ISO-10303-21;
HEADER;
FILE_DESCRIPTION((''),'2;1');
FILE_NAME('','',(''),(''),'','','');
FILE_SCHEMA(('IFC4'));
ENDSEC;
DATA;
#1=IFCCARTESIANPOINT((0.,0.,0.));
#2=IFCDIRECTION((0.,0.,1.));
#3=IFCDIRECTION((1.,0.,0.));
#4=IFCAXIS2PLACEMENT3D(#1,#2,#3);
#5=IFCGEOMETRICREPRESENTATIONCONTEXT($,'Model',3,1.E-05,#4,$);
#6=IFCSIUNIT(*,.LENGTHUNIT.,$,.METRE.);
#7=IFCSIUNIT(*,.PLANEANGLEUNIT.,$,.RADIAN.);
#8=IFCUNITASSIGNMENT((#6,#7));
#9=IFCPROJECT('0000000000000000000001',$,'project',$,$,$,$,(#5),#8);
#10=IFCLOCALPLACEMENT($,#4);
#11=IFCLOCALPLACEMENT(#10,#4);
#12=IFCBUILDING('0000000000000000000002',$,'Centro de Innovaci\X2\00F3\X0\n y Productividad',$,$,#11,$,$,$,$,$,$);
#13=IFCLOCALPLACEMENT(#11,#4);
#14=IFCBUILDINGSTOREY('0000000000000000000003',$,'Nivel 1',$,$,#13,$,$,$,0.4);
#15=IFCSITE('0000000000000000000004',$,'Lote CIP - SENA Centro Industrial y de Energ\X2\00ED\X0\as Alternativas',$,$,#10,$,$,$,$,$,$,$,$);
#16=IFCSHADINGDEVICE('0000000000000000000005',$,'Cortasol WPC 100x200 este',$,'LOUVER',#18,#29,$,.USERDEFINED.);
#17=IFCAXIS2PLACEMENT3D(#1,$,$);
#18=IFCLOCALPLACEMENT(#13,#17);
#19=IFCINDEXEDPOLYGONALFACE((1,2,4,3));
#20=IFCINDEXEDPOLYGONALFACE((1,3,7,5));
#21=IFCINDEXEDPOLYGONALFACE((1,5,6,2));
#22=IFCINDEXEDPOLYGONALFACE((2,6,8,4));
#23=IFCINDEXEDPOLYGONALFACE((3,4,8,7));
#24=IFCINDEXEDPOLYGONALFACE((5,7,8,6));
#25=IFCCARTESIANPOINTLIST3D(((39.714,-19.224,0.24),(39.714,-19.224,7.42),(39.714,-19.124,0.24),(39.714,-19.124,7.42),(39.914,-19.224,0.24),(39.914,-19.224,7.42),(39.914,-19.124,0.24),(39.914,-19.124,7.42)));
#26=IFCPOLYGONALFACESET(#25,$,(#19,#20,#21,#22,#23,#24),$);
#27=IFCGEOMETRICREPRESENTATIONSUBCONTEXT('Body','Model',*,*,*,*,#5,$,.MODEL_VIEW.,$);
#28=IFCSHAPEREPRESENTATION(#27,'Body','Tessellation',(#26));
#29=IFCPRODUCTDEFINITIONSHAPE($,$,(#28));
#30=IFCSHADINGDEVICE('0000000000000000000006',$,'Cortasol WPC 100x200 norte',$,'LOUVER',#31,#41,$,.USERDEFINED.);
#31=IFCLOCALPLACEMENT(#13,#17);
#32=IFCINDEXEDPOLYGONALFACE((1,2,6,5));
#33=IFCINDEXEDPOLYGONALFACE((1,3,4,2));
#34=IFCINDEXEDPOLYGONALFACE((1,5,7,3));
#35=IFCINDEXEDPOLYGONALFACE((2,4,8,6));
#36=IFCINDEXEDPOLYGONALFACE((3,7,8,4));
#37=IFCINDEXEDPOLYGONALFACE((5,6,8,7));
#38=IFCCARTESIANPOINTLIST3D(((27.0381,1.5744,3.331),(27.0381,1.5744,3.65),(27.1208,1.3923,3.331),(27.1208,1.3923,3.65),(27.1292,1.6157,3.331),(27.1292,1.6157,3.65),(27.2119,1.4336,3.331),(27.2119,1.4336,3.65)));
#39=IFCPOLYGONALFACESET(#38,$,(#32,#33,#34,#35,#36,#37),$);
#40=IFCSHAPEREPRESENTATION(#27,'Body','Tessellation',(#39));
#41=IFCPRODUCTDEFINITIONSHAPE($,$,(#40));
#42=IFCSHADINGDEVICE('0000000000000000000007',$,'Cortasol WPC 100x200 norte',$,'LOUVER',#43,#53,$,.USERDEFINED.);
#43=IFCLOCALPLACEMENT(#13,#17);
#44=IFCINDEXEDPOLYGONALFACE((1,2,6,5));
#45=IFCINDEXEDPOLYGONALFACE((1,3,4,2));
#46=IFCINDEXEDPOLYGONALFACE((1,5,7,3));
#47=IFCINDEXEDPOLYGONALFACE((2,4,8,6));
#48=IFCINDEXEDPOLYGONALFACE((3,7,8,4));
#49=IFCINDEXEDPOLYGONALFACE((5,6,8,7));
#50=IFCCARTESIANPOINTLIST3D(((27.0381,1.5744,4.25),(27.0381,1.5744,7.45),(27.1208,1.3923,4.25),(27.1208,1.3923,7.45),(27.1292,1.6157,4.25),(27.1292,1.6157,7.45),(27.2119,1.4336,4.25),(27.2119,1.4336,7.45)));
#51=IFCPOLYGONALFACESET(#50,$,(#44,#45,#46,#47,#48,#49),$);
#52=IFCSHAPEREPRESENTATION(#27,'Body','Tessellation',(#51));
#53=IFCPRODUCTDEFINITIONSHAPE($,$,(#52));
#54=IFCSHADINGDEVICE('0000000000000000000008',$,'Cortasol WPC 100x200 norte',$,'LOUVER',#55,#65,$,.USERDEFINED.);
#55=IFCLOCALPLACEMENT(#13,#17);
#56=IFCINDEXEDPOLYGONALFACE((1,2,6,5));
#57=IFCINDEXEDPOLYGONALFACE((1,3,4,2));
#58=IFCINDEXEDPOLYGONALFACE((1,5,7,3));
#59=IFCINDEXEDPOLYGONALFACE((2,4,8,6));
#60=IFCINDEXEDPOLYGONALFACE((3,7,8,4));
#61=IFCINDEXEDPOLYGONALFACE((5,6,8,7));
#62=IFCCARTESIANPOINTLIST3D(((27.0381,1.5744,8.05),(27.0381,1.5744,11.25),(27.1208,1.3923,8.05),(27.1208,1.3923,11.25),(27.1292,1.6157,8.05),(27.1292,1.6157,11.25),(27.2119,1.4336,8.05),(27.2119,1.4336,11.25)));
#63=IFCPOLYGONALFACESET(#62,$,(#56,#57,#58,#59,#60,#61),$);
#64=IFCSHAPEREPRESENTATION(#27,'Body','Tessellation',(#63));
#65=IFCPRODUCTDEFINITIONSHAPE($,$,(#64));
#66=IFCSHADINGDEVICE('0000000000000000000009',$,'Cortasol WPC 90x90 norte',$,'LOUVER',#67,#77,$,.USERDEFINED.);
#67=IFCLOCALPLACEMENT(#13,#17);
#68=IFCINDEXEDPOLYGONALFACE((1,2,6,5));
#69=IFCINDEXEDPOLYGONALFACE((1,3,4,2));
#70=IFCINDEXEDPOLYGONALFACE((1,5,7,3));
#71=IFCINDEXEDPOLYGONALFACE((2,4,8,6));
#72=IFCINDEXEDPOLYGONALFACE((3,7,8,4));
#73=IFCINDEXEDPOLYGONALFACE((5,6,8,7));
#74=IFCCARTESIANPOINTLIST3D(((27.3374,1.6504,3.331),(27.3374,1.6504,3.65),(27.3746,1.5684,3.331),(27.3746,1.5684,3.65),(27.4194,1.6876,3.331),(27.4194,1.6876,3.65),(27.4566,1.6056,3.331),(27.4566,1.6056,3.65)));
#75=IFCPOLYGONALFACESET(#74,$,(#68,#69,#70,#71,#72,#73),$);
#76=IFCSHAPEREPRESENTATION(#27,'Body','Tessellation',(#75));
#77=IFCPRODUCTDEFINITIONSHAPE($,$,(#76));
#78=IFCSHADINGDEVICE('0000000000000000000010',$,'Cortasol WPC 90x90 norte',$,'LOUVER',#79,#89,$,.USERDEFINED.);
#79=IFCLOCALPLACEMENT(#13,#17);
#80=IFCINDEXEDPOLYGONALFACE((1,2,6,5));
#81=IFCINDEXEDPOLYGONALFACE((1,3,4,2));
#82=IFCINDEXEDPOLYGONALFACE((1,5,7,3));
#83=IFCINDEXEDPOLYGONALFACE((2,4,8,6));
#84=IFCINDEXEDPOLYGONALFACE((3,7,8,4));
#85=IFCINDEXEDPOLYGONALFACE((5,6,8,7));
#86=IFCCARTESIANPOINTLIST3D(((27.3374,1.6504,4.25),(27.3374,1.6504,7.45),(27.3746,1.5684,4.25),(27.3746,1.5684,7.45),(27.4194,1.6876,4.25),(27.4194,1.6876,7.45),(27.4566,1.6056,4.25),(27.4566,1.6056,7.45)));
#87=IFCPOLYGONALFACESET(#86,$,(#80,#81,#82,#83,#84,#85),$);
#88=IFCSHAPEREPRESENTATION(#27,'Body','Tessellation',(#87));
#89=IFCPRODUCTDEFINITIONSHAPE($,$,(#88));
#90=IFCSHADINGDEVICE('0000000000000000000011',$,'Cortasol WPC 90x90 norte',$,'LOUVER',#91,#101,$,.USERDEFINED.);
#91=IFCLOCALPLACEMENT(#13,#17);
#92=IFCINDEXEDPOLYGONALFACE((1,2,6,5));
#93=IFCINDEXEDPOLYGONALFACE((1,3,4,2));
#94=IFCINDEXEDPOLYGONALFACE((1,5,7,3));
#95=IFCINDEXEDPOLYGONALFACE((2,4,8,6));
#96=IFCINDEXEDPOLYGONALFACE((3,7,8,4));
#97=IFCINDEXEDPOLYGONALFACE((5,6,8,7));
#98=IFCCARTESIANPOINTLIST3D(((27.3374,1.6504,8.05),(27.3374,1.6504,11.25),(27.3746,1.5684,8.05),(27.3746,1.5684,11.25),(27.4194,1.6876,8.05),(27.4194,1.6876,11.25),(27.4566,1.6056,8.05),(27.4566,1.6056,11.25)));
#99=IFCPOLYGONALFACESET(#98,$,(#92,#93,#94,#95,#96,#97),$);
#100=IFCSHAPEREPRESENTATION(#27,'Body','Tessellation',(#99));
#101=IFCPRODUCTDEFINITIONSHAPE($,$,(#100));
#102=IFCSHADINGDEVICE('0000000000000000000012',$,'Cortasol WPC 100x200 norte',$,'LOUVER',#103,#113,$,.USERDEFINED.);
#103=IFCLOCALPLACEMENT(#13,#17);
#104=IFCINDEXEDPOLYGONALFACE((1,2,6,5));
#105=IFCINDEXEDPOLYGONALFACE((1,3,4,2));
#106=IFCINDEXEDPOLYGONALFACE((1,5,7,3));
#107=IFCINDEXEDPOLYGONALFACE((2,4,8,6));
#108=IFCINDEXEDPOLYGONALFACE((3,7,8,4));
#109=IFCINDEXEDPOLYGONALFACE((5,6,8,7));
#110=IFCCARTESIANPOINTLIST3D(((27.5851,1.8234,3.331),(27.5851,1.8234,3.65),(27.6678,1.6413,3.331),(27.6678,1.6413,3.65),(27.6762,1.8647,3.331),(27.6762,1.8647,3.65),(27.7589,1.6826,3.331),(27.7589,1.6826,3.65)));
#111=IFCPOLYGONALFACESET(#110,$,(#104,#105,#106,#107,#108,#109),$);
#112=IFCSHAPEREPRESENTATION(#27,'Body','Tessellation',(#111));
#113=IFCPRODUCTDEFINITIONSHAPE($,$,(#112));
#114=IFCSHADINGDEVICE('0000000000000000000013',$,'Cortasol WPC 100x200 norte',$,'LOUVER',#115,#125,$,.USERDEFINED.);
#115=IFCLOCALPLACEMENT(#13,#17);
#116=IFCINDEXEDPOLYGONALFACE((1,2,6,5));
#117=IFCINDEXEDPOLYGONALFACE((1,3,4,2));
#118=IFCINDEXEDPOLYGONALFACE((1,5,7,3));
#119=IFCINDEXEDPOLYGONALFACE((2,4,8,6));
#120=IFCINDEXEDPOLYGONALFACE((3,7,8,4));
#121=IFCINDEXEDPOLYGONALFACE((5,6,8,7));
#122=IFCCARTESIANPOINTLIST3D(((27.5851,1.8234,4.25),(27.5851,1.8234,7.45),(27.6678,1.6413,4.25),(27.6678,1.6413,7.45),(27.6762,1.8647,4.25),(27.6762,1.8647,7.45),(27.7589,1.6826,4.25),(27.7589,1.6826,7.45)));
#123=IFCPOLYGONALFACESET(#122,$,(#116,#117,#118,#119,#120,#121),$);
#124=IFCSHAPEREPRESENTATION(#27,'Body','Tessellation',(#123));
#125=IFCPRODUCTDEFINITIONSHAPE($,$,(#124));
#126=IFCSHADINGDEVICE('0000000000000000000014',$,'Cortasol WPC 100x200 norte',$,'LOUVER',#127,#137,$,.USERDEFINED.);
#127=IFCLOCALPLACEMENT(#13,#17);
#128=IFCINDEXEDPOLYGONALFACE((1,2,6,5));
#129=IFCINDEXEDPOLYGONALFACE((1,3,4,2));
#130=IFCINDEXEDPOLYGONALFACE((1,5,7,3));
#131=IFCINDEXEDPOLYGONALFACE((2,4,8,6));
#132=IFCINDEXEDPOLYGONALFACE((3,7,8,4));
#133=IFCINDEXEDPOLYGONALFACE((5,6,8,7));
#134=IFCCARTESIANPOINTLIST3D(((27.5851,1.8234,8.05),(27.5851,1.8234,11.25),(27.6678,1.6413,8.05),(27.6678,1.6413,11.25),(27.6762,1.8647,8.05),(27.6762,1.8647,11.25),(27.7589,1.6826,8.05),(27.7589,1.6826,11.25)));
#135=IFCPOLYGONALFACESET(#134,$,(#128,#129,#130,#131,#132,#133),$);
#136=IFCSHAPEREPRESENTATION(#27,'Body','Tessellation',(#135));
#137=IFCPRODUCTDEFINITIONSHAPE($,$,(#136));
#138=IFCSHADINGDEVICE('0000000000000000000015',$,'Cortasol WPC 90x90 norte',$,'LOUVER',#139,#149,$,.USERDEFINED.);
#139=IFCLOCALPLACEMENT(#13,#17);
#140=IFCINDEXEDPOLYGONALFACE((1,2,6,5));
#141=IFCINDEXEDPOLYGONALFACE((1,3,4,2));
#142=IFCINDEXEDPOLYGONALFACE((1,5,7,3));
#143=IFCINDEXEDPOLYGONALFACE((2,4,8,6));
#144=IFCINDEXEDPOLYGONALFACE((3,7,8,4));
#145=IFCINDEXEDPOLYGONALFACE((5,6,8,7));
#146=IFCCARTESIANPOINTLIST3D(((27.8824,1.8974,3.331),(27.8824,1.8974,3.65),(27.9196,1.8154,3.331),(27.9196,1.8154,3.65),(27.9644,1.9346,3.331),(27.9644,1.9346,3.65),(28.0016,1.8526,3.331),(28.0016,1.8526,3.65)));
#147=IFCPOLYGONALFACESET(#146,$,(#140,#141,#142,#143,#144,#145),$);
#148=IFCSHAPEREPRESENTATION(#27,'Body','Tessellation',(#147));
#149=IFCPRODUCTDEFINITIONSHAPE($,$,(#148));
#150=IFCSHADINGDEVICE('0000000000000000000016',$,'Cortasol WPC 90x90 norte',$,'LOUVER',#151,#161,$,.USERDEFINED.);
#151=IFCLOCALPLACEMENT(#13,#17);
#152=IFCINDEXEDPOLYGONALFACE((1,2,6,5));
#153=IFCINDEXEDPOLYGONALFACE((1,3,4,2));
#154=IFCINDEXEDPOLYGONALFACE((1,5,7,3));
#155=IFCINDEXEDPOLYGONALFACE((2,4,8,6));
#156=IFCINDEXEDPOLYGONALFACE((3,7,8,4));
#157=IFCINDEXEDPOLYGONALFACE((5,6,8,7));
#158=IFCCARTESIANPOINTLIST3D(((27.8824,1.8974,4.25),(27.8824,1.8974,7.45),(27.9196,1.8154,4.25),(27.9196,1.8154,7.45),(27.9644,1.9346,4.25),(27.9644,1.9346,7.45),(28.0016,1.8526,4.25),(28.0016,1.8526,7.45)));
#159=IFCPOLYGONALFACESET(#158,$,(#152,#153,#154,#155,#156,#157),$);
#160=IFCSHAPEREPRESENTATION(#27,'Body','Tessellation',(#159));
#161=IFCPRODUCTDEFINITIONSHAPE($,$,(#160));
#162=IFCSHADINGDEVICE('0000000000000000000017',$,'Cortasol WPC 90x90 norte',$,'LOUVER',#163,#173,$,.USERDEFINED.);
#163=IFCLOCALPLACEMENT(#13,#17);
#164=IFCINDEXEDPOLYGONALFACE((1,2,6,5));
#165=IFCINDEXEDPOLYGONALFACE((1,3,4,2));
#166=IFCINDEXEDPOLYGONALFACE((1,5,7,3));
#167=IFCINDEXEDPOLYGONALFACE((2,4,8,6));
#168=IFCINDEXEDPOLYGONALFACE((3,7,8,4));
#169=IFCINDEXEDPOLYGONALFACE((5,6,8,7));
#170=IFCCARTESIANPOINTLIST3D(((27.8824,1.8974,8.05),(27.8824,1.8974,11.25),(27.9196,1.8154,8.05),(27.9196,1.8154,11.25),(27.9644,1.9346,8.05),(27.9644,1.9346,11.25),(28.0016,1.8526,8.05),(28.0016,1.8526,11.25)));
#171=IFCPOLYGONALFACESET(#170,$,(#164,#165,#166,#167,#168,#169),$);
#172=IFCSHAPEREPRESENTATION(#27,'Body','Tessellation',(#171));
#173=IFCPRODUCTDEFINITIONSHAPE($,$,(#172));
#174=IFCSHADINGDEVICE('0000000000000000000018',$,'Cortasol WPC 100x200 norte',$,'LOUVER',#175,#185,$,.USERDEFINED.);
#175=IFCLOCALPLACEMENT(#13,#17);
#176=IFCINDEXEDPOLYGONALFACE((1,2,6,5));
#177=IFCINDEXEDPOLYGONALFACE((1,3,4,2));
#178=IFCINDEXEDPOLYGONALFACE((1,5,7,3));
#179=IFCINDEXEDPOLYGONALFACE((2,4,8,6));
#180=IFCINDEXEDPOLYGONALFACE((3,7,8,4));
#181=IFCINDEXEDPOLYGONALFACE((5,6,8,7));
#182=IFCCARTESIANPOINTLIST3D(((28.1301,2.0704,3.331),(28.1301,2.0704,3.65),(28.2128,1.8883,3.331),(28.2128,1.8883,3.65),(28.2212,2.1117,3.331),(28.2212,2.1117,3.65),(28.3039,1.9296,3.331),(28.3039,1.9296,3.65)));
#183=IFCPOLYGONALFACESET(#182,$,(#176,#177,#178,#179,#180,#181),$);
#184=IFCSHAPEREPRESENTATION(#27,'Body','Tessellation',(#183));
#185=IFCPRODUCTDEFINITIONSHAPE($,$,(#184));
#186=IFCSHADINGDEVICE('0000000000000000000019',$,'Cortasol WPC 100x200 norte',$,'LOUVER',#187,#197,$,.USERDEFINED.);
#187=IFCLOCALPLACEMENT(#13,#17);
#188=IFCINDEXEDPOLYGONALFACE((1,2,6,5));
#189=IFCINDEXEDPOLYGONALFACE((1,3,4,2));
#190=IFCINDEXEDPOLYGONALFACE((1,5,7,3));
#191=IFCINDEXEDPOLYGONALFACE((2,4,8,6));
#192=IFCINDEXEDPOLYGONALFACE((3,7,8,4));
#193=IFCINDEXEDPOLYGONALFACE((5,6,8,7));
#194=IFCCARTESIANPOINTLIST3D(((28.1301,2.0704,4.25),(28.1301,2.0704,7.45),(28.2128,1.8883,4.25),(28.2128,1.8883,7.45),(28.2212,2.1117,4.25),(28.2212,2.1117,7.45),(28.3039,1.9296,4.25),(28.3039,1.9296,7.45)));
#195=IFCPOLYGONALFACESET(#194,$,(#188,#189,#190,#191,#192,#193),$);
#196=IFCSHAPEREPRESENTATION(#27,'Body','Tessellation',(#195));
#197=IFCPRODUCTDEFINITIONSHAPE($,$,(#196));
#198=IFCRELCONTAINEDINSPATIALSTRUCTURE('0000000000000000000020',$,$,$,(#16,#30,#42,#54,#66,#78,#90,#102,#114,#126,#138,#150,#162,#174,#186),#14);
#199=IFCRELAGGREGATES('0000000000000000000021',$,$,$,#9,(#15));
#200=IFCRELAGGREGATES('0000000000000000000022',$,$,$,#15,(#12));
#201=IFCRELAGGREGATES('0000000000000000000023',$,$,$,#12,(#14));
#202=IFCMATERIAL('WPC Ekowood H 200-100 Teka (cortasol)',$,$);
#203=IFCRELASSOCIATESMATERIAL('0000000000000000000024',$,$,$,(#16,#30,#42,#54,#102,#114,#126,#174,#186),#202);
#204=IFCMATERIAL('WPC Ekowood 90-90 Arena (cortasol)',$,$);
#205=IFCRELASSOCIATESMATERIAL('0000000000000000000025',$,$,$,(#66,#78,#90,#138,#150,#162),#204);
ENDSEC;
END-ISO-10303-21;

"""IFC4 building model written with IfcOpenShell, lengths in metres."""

from ifc_helpers import new_model, si_unit, frame, origin_with_axes, place, context, subcontext, project, spatial, polyline, outline, extrude, material, element, save


model = new_model("IFC4")

# Units and contexts
model_context = context("Model", 3, precision=1e-05, world=origin_with_axes())
body_context = subcontext(model_context, "Body", "Model", "MODEL_VIEW")
ifc_project = project(units=[si_unit("LENGTHUNIT", "METRE"), si_unit("PLANEANGLEUNIT", "RADIAN")], contexts=[model_context])

# Site, building, storey
site_placement = place(None, origin_with_axes())
site = spatial("IfcSite", under=ifc_project, at=site_placement, Name="Lote CIP - SENA Centro Industrial y de Energías Alternativas")
building_placement = place(site_placement, origin_with_axes())
building = spatial("IfcBuilding", under=site, at=building_placement, Name="Centro de Innovación y Productividad")
storey_placement = place(building_placement, origin_with_axes())
storey = spatial("IfcBuildingStorey", under=building, at=storey_placement, Name="Nivel 1", Elevation=0.4)

# Shading devices
ifc_material_1 = material(Name="WPC Ekowood H 200-100 Teka (cortasol)")
shading_device_1_placement = place(storey_placement, origin_with_axes())
element("IfcShadingDevice", 1, at=shading_device_1_placement, inside=storey, material=ifc_material_1, Name="Cortasol WPC 100x200 este", ObjectType="LOUVER", PredefinedType="USERDEFINED", context=body_context, shape_type="SweptSolid", body=[
    extrude(outline(polyline([(39.914, -19.224), (39.714, -19.224), (39.714, -19.124), (39.914, -19.124), (39.914, -19.224)])), frame((0.0, 0.0, 0.24)), (0.0, 0.0, 1.0), 7.18),
])
shading_device_2_placement = place(storey_placement, origin_with_axes())
element("IfcShadingDevice", 2, at=shading_device_2_placement, inside=storey, material=ifc_material_1, Name="Cortasol WPC 100x200 norte", ObjectType="LOUVER", PredefinedType="USERDEFINED", context=body_context, shape_type="SweptSolid", body=[
    extrude(outline(polyline([(27.1208, 1.3923), (27.0381, 1.5744), (27.1292, 1.6157), (27.2119, 1.4336), (27.1208, 1.3923)])), frame((0.0, 0.0, 3.331)), (0.0, 0.0, 1.0), 0.319),
])
shading_device_3_placement = place(storey_placement, origin_with_axes())
element("IfcShadingDevice", 3, at=shading_device_3_placement, inside=storey, material=ifc_material_1, Name="Cortasol WPC 100x200 norte", ObjectType="LOUVER", PredefinedType="USERDEFINED", context=body_context, shape_type="SweptSolid", body=[
    extrude(outline(polyline([(27.1208, 1.3923), (27.0381, 1.5744), (27.1292, 1.6157), (27.2119, 1.4336), (27.1208, 1.3923)])), frame((0.0, 0.0, 4.25)), (0.0, 0.0, 1.0), 3.2),
])
shading_device_4_placement = place(storey_placement, origin_with_axes())
element("IfcShadingDevice", 4, at=shading_device_4_placement, inside=storey, material=ifc_material_1, Name="Cortasol WPC 100x200 norte", ObjectType="LOUVER", PredefinedType="USERDEFINED", context=body_context, shape_type="SweptSolid", body=[
    extrude(outline(polyline([(27.1208, 1.3923), (27.0381, 1.5744), (27.1292, 1.6157), (27.2119, 1.4336), (27.1208, 1.3923)])), frame((0.0, 0.0, 8.05)), (0.0, 0.0, 1.0), 3.2),
])
ifc_material_2 = material(Name="WPC Ekowood 90-90 Arena (cortasol)")
shading_device_5_placement = place(storey_placement, origin_with_axes())
element("IfcShadingDevice", 5, at=shading_device_5_placement, inside=storey, material=ifc_material_2, Name="Cortasol WPC 90x90 norte", ObjectType="LOUVER", PredefinedType="USERDEFINED", context=body_context, shape_type="SweptSolid", body=[
    extrude(outline(polyline([(27.3746, 1.5684), (27.3374, 1.6504), (27.4194, 1.6876), (27.4566, 1.6056), (27.3746, 1.5684)])), frame((0.0, 0.0, 3.331)), (0.0, 0.0, 1.0), 0.319),
])
shading_device_6_placement = place(storey_placement, origin_with_axes())
element("IfcShadingDevice", 6, at=shading_device_6_placement, inside=storey, material=ifc_material_2, Name="Cortasol WPC 90x90 norte", ObjectType="LOUVER", PredefinedType="USERDEFINED", context=body_context, shape_type="SweptSolid", body=[
    extrude(outline(polyline([(27.3746, 1.5684), (27.3374, 1.6504), (27.4194, 1.6876), (27.4566, 1.6056), (27.3746, 1.5684)])), frame((0.0, 0.0, 4.25)), (0.0, 0.0, 1.0), 3.2),
])
shading_device_7_placement = place(storey_placement, origin_with_axes())
element("IfcShadingDevice", 7, at=shading_device_7_placement, inside=storey, material=ifc_material_2, Name="Cortasol WPC 90x90 norte", ObjectType="LOUVER", PredefinedType="USERDEFINED", context=body_context, shape_type="SweptSolid", body=[
    extrude(outline(polyline([(27.3746, 1.5684), (27.3374, 1.6504), (27.4194, 1.6876), (27.4566, 1.6056), (27.3746, 1.5684)])), frame((0.0, 0.0, 8.05)), (0.0, 0.0, 1.0), 3.2),
])
shading_device_8_placement = place(storey_placement, origin_with_axes())
element("IfcShadingDevice", 8, at=shading_device_8_placement, inside=storey, material=ifc_material_1, Name="Cortasol WPC 100x200 norte", ObjectType="LOUVER", PredefinedType="USERDEFINED", context=body_context, shape_type="SweptSolid", body=[
    extrude(outline(polyline([(27.6678, 1.6413), (27.5851, 1.8234), (27.6762, 1.8647), (27.7589, 1.6826), (27.6678, 1.6413)])), frame((0.0, 0.0, 3.331)), (0.0, 0.0, 1.0), 0.319),
])
shading_device_9_placement = place(storey_placement, origin_with_axes())
element("IfcShadingDevice", 9, at=shading_device_9_placement, inside=storey, material=ifc_material_1, Name="Cortasol WPC 100x200 norte", ObjectType="LOUVER", PredefinedType="USERDEFINED", context=body_context, shape_type="SweptSolid", body=[
    extrude(outline(polyline([(27.6678, 1.6413), (27.5851, 1.8234), (27.6762, 1.8647), (27.7589, 1.6826), (27.6678, 1.6413)])), frame((0.0, 0.0, 4.25)), (0.0, 0.0, 1.0), 3.2),
])
shading_device_10_placement = place(storey_placement, origin_with_axes())
element("IfcShadingDevice", 10, at=shading_device_10_placement, inside=storey, material=ifc_material_1, Name="Cortasol WPC 100x200 norte", ObjectType="LOUVER", PredefinedType="USERDEFINED", context=body_context, shape_type="SweptSolid", body=[
    extrude(outline(polyline([(27.6678, 1.6413), (27.5851, 1.8234), (27.6762, 1.8647), (27.7589, 1.6826), (27.6678, 1.6413)])), frame((0.0, 0.0, 8.05)), (0.0, 0.0, 1.0), 3.2),
])
shading_device_11_placement = place(storey_placement, origin_with_axes())
element("IfcShadingDevice", 11, at=shading_device_11_placement, inside=storey, material=ifc_material_2, Name="Cortasol WPC 90x90 norte", ObjectType="LOUVER", PredefinedType="USERDEFINED", context=body_context, shape_type="SweptSolid", body=[
    extrude(outline(polyline([(27.9196, 1.8154), (27.8824, 1.8974), (27.9644, 1.9346), (28.0016, 1.8526), (27.9196, 1.8154)])), frame((0.0, 0.0, 3.331)), (0.0, 0.0, 1.0), 0.319),
])
shading_device_12_placement = place(storey_placement, origin_with_axes())
element("IfcShadingDevice", 12, at=shading_device_12_placement, inside=storey, material=ifc_material_2, Name="Cortasol WPC 90x90 norte", ObjectType="LOUVER", PredefinedType="USERDEFINED", context=body_context, shape_type="SweptSolid", body=[
    extrude(outline(polyline([(27.9196, 1.8154), (27.8824, 1.8974), (27.9644, 1.9346), (28.0016, 1.8526), (27.9196, 1.8154)])), frame((0.0, 0.0, 4.25)), (0.0, 0.0, 1.0), 3.2),
])
shading_device_13_placement = place(storey_placement, origin_with_axes())
element("IfcShadingDevice", 13, at=shading_device_13_placement, inside=storey, material=ifc_material_2, Name="Cortasol WPC 90x90 norte", ObjectType="LOUVER", PredefinedType="USERDEFINED", context=body_context, shape_type="SweptSolid", body=[
    extrude(outline(polyline([(27.9196, 1.8154), (27.8824, 1.8974), (27.9644, 1.9346), (28.0016, 1.8526), (27.9196, 1.8154)])), frame((0.0, 0.0, 8.05)), (0.0, 0.0, 1.0), 3.2),
])
shading_device_14_placement = place(storey_placement, origin_with_axes())
element("IfcShadingDevice", 14, at=shading_device_14_placement, inside=storey, material=ifc_material_1, Name="Cortasol WPC 100x200 norte", ObjectType="LOUVER", PredefinedType="USERDEFINED", context=body_context, shape_type="SweptSolid", body=[
    extrude(outline(polyline([(28.2128, 1.8883), (28.1301, 2.0704), (28.2212, 2.1117), (28.3039, 1.9296), (28.2128, 1.8883)])), frame((0.0, 0.0, 3.331)), (0.0, 0.0, 1.0), 0.319),
])
shading_device_15_placement = place(storey_placement, origin_with_axes())
element("IfcShadingDevice", 15, at=shading_device_15_placement, inside=storey, material=ifc_material_1, Name="Cortasol WPC 100x200 norte", ObjectType="LOUVER", PredefinedType="USERDEFINED", context=body_context, shape_type="SweptSolid", body=[
    extrude(outline(polyline([(28.2128, 1.8883), (28.1301, 2.0704), (28.2212, 2.1117), (28.3039, 1.9296), (28.2128, 1.8883)])), frame((0.0, 0.0, 4.25)), (0.0, 0.0, 1.0), 3.2),
])

save(model, "model.ifc")
